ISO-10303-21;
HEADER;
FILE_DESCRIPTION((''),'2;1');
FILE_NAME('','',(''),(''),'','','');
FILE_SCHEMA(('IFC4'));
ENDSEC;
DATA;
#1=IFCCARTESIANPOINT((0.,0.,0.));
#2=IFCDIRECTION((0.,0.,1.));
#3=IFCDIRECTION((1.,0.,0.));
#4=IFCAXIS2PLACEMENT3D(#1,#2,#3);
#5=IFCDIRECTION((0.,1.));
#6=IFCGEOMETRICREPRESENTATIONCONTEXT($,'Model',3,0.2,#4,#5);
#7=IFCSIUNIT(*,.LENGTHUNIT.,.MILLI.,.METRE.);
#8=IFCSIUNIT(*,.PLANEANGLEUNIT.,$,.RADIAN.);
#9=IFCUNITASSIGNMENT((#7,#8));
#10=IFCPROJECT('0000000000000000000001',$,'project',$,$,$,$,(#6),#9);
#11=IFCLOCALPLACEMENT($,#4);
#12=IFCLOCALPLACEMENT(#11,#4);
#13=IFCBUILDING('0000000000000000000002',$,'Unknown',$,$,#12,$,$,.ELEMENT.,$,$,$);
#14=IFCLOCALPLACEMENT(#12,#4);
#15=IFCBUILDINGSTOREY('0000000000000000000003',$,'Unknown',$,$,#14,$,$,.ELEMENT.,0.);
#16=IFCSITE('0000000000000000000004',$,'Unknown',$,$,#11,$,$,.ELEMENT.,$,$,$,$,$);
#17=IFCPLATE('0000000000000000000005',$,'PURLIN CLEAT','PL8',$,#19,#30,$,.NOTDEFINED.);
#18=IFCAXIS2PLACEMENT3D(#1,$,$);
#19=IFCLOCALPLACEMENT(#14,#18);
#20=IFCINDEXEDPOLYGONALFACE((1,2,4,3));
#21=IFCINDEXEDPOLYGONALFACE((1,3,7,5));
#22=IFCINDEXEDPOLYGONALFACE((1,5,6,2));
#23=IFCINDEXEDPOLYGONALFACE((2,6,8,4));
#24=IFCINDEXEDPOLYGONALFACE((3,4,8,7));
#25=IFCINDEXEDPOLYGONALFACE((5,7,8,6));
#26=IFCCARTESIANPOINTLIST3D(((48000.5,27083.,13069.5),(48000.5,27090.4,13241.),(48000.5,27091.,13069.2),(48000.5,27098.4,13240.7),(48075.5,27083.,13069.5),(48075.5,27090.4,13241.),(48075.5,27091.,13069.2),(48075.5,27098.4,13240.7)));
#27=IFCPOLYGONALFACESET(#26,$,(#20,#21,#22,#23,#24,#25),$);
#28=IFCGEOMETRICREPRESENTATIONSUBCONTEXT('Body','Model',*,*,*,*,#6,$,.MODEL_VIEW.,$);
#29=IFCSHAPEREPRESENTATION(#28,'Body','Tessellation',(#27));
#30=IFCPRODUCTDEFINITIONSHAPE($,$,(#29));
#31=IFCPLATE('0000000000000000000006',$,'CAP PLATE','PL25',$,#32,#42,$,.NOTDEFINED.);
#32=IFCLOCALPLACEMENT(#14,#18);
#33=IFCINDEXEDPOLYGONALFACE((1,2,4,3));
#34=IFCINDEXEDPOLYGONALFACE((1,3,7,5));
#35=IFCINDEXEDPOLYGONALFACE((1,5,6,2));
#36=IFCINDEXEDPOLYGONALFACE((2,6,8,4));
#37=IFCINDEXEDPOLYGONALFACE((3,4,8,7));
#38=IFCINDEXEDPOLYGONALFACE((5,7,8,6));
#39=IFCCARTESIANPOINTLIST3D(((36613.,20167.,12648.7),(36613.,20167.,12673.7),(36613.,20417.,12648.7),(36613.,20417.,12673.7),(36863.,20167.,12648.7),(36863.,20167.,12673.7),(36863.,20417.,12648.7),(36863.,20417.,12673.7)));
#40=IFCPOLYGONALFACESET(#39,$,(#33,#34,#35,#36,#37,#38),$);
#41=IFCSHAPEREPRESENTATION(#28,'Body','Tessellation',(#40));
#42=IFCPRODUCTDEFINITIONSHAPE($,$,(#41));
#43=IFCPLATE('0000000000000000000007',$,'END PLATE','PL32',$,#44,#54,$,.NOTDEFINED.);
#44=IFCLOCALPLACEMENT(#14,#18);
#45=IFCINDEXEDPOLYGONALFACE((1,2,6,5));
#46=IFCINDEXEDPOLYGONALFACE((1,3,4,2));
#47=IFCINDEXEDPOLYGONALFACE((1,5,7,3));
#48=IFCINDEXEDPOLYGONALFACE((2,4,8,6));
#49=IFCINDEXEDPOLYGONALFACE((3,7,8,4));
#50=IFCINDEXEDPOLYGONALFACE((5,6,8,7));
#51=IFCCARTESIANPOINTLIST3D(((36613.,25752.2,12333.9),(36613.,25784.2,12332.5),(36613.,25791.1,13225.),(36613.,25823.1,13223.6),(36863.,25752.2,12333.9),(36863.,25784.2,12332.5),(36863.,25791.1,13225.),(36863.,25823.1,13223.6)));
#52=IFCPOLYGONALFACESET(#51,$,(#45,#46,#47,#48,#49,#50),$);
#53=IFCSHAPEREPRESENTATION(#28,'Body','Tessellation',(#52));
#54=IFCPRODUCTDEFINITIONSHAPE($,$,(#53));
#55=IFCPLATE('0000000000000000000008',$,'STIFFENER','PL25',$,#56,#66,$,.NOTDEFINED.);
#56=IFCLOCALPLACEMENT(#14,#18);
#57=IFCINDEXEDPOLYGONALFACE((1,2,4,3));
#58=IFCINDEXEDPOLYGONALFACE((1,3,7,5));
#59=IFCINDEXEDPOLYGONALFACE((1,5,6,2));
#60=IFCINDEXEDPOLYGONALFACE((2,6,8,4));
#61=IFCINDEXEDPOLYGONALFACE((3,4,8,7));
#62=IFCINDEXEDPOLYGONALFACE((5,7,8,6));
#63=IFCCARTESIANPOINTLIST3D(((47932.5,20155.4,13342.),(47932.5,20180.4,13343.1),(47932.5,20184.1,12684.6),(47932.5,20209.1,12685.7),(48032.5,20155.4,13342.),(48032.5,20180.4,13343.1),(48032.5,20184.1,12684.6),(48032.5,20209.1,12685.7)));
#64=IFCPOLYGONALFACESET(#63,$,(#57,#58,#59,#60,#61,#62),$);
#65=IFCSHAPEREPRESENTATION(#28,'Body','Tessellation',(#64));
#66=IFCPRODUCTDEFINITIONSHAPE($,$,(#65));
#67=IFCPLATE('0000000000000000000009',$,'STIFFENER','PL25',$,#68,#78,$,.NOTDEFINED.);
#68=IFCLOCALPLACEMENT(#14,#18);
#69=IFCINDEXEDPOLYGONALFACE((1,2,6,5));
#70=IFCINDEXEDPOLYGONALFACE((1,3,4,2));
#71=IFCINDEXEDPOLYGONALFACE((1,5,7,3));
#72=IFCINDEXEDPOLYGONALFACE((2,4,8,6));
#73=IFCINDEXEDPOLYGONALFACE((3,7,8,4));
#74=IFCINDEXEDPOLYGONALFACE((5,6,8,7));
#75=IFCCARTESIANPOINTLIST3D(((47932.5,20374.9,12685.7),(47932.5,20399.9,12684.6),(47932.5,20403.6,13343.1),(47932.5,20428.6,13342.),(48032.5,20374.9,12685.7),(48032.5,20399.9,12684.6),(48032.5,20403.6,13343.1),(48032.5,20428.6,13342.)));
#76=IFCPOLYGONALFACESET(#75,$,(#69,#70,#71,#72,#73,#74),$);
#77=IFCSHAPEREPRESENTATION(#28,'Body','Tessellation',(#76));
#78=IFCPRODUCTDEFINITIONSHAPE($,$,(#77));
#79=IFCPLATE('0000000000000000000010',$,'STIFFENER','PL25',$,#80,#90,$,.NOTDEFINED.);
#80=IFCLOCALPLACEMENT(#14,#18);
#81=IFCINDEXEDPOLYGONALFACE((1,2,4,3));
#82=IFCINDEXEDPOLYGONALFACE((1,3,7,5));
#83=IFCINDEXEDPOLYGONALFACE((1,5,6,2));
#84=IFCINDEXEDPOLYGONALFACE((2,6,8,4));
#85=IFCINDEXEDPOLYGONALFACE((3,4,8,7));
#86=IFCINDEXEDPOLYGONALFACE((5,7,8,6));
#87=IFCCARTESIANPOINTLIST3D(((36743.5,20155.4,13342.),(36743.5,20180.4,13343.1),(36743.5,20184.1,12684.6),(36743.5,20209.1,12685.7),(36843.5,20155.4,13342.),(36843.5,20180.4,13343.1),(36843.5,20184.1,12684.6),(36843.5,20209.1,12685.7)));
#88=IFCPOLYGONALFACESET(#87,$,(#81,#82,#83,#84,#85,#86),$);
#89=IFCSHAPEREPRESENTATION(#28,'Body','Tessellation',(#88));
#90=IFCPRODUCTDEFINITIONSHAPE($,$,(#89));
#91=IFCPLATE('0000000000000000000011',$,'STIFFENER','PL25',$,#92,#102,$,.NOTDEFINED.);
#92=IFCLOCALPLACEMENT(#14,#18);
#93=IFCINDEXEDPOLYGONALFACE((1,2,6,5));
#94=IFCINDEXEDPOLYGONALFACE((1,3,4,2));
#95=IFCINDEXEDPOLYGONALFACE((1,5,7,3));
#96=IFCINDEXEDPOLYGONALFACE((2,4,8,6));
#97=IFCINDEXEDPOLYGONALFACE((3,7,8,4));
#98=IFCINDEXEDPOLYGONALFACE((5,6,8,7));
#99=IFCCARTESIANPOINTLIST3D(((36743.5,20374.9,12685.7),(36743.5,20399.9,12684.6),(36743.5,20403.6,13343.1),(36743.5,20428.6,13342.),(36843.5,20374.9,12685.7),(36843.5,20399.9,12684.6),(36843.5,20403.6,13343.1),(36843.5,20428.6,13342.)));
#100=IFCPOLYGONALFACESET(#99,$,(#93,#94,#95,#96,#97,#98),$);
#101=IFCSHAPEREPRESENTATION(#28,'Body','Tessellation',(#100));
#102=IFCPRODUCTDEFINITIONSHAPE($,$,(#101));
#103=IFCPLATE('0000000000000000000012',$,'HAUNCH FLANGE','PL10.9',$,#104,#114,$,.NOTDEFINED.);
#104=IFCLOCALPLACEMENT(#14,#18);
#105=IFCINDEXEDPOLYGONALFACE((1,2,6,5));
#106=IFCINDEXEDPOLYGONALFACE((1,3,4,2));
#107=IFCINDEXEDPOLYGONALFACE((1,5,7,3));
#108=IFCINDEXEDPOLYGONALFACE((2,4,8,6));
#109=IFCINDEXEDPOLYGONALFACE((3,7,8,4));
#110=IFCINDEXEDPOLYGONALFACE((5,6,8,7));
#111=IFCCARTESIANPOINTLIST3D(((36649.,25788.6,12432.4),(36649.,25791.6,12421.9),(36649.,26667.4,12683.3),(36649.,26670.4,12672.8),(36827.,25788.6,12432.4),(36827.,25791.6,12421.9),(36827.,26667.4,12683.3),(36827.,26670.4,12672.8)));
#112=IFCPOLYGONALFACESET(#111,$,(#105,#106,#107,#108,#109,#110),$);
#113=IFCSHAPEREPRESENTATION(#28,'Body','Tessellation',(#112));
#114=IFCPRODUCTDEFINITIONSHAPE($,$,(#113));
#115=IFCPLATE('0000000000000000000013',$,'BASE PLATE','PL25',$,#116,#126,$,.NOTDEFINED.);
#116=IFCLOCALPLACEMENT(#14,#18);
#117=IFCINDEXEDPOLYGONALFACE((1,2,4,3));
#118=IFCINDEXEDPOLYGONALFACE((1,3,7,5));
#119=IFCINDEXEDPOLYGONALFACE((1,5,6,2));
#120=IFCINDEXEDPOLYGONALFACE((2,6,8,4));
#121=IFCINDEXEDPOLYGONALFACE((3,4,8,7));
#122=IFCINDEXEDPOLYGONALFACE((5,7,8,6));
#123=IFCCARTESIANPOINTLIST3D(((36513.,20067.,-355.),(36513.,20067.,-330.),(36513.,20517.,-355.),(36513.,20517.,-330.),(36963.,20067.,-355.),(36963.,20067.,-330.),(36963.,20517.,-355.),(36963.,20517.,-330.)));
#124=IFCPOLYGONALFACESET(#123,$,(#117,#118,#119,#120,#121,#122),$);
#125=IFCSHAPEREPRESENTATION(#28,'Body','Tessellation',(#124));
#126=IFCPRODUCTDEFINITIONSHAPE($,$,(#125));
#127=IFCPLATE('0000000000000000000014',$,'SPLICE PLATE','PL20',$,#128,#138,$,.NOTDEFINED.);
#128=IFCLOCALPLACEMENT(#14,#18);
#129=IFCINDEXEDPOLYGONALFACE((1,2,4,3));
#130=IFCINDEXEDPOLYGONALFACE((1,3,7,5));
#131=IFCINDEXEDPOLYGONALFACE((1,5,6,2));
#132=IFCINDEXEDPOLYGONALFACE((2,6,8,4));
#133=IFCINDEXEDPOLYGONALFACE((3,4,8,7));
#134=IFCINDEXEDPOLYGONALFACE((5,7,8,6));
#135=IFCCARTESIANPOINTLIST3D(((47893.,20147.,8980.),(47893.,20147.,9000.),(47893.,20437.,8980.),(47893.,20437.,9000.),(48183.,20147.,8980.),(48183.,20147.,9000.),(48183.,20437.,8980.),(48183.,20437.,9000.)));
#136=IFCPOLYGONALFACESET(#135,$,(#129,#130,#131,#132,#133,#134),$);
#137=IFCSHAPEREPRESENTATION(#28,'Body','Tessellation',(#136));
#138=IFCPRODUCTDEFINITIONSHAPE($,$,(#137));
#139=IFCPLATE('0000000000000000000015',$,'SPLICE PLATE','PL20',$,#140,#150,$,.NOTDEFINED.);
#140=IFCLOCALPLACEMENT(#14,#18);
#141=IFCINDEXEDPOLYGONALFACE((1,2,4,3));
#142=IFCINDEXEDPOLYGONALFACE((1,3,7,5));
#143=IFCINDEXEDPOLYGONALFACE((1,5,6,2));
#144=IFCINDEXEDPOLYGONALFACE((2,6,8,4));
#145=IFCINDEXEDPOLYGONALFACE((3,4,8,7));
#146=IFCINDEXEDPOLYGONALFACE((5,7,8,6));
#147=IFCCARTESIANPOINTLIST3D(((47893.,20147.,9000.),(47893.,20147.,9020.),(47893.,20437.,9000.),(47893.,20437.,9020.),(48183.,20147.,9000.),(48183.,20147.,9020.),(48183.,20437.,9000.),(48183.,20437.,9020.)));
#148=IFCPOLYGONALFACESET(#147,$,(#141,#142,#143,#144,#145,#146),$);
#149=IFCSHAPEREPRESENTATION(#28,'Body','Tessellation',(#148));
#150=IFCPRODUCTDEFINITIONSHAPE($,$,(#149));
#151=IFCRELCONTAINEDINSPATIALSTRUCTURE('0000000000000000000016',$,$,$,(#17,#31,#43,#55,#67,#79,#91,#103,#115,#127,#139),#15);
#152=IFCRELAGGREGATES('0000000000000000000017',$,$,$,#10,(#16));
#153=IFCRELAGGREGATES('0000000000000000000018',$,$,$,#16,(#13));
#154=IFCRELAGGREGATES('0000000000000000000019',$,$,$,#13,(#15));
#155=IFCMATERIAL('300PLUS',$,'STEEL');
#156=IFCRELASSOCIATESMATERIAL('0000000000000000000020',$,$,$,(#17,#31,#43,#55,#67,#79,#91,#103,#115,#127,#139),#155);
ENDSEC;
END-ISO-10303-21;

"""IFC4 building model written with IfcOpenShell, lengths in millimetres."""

from ifc_helpers import new_model, si_unit, direction, frame, origin_with_axes, place, context, subcontext, project, spatial, line, indexed_curve, outline, extrude, material, element, save


model = new_model("IFC4")

# Units and contexts
model_context = context("Model", 3, precision=0.2, world=origin_with_axes(), true_north=direction((0.0, 1.0)))
body_context = subcontext(model_context, "Body", "Model", "MODEL_VIEW")
ifc_project = project(units=[si_unit("LENGTHUNIT", "METRE", prefix="MILLI"), si_unit("PLANEANGLEUNIT", "RADIAN")], contexts=[model_context])

# Site, building, storey
site_placement = place(None, origin_with_axes())
site = spatial("IfcSite", under=ifc_project, at=site_placement, Name="Unknown", CompositionType="ELEMENT")
building_placement = place(site_placement, origin_with_axes())
building = spatial("IfcBuilding", under=site, at=building_placement, Name="Unknown", CompositionType="ELEMENT")
storey_placement = place(building_placement, origin_with_axes())
storey = spatial("IfcBuildingStorey", under=building, at=storey_placement, Name="Unknown", CompositionType="ELEMENT", Elevation=0.0)

# Shared definitions
ifc_material_1 = material(Name="300PLUS", Category="STEEL")

# Plates
plate_1_placement = place(storey_placement, frame((48000.5, 27087.0, 13069.4), z_axis=(0.0, -0.99907, 0.043109), x_axis=(1.0, 0.0, 0.0)))
element("IfcPlate", 1, at=plate_1_placement, inside=storey, material=ifc_material_1, Name="PURLIN CLEAT", Description="PL8", PredefinedType="NOTDEFINED", context=body_context, shape_type="SolidModel", body=[
    extrude(outline(indexed_curve([(0.0, 0.0), (75.0, 0.0), (75.0, 171.7), (0.0, 171.7)], segments=[line(1, 2, 3, 4, 1)])), frame((0.0, 0.0, 4.0), z_axis=(0.0, 0.0, 1.0), x_axis=(1.0, 0.0, 0.0)), (0.0, 0.0, -1.0), 8.0),
])
plate_2_placement = place(storey_placement, frame((36863.0, 20167.0, 12661.2), z_axis=(0.0, 0.0, 1.0), x_axis=(0.0, 1.0, 0.0)))
element("IfcPlate", 2, at=plate_2_placement, inside=storey, material=ifc_material_1, Name="CAP PLATE", Description="PL25", PredefinedType="NOTDEFINED", context=body_context, shape_type="SolidModel", body=[
    extrude(outline(indexed_curve([(0.0, 0.0), (250.0, 0.0), (250.0, 250.0), (0.0, 250.0)], segments=[line(1, 2, 3, 4, 1)])), frame((0.0, 0.0, 12.5), z_axis=(0.0, 0.0, 1.0), x_axis=(1.0, 0.0, 0.0)), (0.0, 0.0, -1.0), 25.0),
])
plate_3_placement = place(storey_placement, frame((36863.0, 25807.1, 13224.3), z_axis=(0.0, -0.999049, 0.043612), x_axis=(-1.0, 0.0, 0.0)))
element("IfcPlate", 3, at=plate_3_placement, inside=storey, material=ifc_material_1, Name="END PLATE", Description="PL32", PredefinedType="NOTDEFINED", context=body_context, shape_type="SolidModel", body=[
    extrude(outline(indexed_curve([(0.0, 0.0), (250.0, 0.0), (250.0, 891.9), (0.0, 891.9)], segments=[line(1, 2, 3, 4, 1)])), frame((0.0, 0.0, 16.0), z_axis=(0.0, 0.0, 1.0), x_axis=(1.0, 0.0, 0.0)), (0.0, 0.0, -1.0), 32.0),
])
for number, where, z_axis, x_axis, name in (
    (4, (47932.5, 20196.6, 12685.1), (0.0, 0.999048, 0.043615), (0.0, -0.043615, 0.999048), "STIFFENER"),
    (5, (48032.5, 20387.4, 12685.1), (0.0, -0.999048, 0.043615), (0.0, 0.043615, 0.999048), "STIFFENER"),
    (6, (36743.5, 20196.6, 12685.1), (0.0, 0.999048, 0.043615), (0.0, -0.043615, 0.999048), "STIFFENER"),
    (7, (36843.5, 20387.4, 12685.1), (0.0, -0.999048, 0.043615), (0.0, 0.043615, 0.999048), "STIFFENER"),
):
    element("IfcPlate", number, at=place(storey_placement, frame(where, z_axis=z_axis, x_axis=x_axis)), inside=storey, material=ifc_material_1, Name=name, Description="PL25", PredefinedType="NOTDEFINED", context=body_context, shape_type="SolidModel", body=[
        extrude(outline(indexed_curve([(0.0, 0.0), (658.0, 0.0), (658.0, 100.0), (0.0, 100.0)], segments=[line(1, 2, 3, 4, 1)])), frame((0.0, 0.0, 12.5), z_axis=(0.0, 0.0, 1.0), x_axis=(1.0, 0.0, 0.0)), (0.0, 0.0, -1.0), 25.0),
    ])
plate_4_placement = place(storey_placement, frame((36827.0, 25790.1, 12427.1), z_axis=(0.0, -0.274533, 0.961578), x_axis=(0.0, 0.961578, 0.274533)))
element("IfcPlate", 8, at=plate_4_placement, inside=storey, material=ifc_material_1, Name="HAUNCH FLANGE", Description="PL10.9", PredefinedType="NOTDEFINED", context=body_context, shape_type="SolidModel", body=[
    extrude(outline(indexed_curve([(0.0, 0.0), (913.9, 0.0), (913.9, 178.0), (0.0, 178.0)], segments=[line(1, 2, 3, 4, 1)])), frame((0.0, 0.0, 5.5), z_axis=(0.0, 0.0, 1.0), x_axis=(1.0, 0.0, 0.0)), (0.0, 0.0, -1.0), 10.9),
])
plate_5_placement = place(storey_placement, frame((36963.0, 20067.0, -342.5), z_axis=(0.0, 0.0, 1.0), x_axis=(0.0, 1.0, 0.0)))
element("IfcPlate", 9, at=plate_5_placement, inside=storey, material=ifc_material_1, Name="BASE PLATE", Description="PL25", PredefinedType="NOTDEFINED", context=body_context, shape_type="SolidModel", body=[
    extrude(outline(indexed_curve([(0.0, 0.0), (450.0, 0.0), (450.0, 450.0), (0.0, 450.0)], segments=[line(1, 2, 3, 4, 1)])), frame((0.0, 0.0, 12.5), z_axis=(0.0, 0.0, 1.0), x_axis=(1.0, 0.0, 0.0)), (0.0, 0.0, -1.0), 25.0),
])
for number, where, z_axis, x_axis, name in (
    (10, (47893.0, 20147.0, 8990.0), (0.0, 0.0, 1.0), (1.0, 0.0, 0.0), "SPLICE PLATE"),
    (11, (47893.0, 20147.0, 9010.0), (0.0, 0.0, 1.0), (1.0, 0.0, 0.0), "SPLICE PLATE"),
):
    element("IfcPlate", number, at=place(storey_placement, frame(where, z_axis=z_axis, x_axis=x_axis)), inside=storey, material=ifc_material_1, Name=name, Description="PL20", PredefinedType="NOTDEFINED", context=body_context, shape_type="SolidModel", body=[
        extrude(outline(indexed_curve([(0.0, 0.0), (290.0, 0.0), (290.0, 290.0), (0.0, 290.0)], segments=[line(1, 2, 3, 4, 1)])), frame((0.0, 0.0, 10.0), z_axis=(0.0, 0.0, 1.0), x_axis=(1.0, 0.0, 0.0)), (0.0, 0.0, -1.0), 20.0),
    ])

save(model, "model.ifc")
